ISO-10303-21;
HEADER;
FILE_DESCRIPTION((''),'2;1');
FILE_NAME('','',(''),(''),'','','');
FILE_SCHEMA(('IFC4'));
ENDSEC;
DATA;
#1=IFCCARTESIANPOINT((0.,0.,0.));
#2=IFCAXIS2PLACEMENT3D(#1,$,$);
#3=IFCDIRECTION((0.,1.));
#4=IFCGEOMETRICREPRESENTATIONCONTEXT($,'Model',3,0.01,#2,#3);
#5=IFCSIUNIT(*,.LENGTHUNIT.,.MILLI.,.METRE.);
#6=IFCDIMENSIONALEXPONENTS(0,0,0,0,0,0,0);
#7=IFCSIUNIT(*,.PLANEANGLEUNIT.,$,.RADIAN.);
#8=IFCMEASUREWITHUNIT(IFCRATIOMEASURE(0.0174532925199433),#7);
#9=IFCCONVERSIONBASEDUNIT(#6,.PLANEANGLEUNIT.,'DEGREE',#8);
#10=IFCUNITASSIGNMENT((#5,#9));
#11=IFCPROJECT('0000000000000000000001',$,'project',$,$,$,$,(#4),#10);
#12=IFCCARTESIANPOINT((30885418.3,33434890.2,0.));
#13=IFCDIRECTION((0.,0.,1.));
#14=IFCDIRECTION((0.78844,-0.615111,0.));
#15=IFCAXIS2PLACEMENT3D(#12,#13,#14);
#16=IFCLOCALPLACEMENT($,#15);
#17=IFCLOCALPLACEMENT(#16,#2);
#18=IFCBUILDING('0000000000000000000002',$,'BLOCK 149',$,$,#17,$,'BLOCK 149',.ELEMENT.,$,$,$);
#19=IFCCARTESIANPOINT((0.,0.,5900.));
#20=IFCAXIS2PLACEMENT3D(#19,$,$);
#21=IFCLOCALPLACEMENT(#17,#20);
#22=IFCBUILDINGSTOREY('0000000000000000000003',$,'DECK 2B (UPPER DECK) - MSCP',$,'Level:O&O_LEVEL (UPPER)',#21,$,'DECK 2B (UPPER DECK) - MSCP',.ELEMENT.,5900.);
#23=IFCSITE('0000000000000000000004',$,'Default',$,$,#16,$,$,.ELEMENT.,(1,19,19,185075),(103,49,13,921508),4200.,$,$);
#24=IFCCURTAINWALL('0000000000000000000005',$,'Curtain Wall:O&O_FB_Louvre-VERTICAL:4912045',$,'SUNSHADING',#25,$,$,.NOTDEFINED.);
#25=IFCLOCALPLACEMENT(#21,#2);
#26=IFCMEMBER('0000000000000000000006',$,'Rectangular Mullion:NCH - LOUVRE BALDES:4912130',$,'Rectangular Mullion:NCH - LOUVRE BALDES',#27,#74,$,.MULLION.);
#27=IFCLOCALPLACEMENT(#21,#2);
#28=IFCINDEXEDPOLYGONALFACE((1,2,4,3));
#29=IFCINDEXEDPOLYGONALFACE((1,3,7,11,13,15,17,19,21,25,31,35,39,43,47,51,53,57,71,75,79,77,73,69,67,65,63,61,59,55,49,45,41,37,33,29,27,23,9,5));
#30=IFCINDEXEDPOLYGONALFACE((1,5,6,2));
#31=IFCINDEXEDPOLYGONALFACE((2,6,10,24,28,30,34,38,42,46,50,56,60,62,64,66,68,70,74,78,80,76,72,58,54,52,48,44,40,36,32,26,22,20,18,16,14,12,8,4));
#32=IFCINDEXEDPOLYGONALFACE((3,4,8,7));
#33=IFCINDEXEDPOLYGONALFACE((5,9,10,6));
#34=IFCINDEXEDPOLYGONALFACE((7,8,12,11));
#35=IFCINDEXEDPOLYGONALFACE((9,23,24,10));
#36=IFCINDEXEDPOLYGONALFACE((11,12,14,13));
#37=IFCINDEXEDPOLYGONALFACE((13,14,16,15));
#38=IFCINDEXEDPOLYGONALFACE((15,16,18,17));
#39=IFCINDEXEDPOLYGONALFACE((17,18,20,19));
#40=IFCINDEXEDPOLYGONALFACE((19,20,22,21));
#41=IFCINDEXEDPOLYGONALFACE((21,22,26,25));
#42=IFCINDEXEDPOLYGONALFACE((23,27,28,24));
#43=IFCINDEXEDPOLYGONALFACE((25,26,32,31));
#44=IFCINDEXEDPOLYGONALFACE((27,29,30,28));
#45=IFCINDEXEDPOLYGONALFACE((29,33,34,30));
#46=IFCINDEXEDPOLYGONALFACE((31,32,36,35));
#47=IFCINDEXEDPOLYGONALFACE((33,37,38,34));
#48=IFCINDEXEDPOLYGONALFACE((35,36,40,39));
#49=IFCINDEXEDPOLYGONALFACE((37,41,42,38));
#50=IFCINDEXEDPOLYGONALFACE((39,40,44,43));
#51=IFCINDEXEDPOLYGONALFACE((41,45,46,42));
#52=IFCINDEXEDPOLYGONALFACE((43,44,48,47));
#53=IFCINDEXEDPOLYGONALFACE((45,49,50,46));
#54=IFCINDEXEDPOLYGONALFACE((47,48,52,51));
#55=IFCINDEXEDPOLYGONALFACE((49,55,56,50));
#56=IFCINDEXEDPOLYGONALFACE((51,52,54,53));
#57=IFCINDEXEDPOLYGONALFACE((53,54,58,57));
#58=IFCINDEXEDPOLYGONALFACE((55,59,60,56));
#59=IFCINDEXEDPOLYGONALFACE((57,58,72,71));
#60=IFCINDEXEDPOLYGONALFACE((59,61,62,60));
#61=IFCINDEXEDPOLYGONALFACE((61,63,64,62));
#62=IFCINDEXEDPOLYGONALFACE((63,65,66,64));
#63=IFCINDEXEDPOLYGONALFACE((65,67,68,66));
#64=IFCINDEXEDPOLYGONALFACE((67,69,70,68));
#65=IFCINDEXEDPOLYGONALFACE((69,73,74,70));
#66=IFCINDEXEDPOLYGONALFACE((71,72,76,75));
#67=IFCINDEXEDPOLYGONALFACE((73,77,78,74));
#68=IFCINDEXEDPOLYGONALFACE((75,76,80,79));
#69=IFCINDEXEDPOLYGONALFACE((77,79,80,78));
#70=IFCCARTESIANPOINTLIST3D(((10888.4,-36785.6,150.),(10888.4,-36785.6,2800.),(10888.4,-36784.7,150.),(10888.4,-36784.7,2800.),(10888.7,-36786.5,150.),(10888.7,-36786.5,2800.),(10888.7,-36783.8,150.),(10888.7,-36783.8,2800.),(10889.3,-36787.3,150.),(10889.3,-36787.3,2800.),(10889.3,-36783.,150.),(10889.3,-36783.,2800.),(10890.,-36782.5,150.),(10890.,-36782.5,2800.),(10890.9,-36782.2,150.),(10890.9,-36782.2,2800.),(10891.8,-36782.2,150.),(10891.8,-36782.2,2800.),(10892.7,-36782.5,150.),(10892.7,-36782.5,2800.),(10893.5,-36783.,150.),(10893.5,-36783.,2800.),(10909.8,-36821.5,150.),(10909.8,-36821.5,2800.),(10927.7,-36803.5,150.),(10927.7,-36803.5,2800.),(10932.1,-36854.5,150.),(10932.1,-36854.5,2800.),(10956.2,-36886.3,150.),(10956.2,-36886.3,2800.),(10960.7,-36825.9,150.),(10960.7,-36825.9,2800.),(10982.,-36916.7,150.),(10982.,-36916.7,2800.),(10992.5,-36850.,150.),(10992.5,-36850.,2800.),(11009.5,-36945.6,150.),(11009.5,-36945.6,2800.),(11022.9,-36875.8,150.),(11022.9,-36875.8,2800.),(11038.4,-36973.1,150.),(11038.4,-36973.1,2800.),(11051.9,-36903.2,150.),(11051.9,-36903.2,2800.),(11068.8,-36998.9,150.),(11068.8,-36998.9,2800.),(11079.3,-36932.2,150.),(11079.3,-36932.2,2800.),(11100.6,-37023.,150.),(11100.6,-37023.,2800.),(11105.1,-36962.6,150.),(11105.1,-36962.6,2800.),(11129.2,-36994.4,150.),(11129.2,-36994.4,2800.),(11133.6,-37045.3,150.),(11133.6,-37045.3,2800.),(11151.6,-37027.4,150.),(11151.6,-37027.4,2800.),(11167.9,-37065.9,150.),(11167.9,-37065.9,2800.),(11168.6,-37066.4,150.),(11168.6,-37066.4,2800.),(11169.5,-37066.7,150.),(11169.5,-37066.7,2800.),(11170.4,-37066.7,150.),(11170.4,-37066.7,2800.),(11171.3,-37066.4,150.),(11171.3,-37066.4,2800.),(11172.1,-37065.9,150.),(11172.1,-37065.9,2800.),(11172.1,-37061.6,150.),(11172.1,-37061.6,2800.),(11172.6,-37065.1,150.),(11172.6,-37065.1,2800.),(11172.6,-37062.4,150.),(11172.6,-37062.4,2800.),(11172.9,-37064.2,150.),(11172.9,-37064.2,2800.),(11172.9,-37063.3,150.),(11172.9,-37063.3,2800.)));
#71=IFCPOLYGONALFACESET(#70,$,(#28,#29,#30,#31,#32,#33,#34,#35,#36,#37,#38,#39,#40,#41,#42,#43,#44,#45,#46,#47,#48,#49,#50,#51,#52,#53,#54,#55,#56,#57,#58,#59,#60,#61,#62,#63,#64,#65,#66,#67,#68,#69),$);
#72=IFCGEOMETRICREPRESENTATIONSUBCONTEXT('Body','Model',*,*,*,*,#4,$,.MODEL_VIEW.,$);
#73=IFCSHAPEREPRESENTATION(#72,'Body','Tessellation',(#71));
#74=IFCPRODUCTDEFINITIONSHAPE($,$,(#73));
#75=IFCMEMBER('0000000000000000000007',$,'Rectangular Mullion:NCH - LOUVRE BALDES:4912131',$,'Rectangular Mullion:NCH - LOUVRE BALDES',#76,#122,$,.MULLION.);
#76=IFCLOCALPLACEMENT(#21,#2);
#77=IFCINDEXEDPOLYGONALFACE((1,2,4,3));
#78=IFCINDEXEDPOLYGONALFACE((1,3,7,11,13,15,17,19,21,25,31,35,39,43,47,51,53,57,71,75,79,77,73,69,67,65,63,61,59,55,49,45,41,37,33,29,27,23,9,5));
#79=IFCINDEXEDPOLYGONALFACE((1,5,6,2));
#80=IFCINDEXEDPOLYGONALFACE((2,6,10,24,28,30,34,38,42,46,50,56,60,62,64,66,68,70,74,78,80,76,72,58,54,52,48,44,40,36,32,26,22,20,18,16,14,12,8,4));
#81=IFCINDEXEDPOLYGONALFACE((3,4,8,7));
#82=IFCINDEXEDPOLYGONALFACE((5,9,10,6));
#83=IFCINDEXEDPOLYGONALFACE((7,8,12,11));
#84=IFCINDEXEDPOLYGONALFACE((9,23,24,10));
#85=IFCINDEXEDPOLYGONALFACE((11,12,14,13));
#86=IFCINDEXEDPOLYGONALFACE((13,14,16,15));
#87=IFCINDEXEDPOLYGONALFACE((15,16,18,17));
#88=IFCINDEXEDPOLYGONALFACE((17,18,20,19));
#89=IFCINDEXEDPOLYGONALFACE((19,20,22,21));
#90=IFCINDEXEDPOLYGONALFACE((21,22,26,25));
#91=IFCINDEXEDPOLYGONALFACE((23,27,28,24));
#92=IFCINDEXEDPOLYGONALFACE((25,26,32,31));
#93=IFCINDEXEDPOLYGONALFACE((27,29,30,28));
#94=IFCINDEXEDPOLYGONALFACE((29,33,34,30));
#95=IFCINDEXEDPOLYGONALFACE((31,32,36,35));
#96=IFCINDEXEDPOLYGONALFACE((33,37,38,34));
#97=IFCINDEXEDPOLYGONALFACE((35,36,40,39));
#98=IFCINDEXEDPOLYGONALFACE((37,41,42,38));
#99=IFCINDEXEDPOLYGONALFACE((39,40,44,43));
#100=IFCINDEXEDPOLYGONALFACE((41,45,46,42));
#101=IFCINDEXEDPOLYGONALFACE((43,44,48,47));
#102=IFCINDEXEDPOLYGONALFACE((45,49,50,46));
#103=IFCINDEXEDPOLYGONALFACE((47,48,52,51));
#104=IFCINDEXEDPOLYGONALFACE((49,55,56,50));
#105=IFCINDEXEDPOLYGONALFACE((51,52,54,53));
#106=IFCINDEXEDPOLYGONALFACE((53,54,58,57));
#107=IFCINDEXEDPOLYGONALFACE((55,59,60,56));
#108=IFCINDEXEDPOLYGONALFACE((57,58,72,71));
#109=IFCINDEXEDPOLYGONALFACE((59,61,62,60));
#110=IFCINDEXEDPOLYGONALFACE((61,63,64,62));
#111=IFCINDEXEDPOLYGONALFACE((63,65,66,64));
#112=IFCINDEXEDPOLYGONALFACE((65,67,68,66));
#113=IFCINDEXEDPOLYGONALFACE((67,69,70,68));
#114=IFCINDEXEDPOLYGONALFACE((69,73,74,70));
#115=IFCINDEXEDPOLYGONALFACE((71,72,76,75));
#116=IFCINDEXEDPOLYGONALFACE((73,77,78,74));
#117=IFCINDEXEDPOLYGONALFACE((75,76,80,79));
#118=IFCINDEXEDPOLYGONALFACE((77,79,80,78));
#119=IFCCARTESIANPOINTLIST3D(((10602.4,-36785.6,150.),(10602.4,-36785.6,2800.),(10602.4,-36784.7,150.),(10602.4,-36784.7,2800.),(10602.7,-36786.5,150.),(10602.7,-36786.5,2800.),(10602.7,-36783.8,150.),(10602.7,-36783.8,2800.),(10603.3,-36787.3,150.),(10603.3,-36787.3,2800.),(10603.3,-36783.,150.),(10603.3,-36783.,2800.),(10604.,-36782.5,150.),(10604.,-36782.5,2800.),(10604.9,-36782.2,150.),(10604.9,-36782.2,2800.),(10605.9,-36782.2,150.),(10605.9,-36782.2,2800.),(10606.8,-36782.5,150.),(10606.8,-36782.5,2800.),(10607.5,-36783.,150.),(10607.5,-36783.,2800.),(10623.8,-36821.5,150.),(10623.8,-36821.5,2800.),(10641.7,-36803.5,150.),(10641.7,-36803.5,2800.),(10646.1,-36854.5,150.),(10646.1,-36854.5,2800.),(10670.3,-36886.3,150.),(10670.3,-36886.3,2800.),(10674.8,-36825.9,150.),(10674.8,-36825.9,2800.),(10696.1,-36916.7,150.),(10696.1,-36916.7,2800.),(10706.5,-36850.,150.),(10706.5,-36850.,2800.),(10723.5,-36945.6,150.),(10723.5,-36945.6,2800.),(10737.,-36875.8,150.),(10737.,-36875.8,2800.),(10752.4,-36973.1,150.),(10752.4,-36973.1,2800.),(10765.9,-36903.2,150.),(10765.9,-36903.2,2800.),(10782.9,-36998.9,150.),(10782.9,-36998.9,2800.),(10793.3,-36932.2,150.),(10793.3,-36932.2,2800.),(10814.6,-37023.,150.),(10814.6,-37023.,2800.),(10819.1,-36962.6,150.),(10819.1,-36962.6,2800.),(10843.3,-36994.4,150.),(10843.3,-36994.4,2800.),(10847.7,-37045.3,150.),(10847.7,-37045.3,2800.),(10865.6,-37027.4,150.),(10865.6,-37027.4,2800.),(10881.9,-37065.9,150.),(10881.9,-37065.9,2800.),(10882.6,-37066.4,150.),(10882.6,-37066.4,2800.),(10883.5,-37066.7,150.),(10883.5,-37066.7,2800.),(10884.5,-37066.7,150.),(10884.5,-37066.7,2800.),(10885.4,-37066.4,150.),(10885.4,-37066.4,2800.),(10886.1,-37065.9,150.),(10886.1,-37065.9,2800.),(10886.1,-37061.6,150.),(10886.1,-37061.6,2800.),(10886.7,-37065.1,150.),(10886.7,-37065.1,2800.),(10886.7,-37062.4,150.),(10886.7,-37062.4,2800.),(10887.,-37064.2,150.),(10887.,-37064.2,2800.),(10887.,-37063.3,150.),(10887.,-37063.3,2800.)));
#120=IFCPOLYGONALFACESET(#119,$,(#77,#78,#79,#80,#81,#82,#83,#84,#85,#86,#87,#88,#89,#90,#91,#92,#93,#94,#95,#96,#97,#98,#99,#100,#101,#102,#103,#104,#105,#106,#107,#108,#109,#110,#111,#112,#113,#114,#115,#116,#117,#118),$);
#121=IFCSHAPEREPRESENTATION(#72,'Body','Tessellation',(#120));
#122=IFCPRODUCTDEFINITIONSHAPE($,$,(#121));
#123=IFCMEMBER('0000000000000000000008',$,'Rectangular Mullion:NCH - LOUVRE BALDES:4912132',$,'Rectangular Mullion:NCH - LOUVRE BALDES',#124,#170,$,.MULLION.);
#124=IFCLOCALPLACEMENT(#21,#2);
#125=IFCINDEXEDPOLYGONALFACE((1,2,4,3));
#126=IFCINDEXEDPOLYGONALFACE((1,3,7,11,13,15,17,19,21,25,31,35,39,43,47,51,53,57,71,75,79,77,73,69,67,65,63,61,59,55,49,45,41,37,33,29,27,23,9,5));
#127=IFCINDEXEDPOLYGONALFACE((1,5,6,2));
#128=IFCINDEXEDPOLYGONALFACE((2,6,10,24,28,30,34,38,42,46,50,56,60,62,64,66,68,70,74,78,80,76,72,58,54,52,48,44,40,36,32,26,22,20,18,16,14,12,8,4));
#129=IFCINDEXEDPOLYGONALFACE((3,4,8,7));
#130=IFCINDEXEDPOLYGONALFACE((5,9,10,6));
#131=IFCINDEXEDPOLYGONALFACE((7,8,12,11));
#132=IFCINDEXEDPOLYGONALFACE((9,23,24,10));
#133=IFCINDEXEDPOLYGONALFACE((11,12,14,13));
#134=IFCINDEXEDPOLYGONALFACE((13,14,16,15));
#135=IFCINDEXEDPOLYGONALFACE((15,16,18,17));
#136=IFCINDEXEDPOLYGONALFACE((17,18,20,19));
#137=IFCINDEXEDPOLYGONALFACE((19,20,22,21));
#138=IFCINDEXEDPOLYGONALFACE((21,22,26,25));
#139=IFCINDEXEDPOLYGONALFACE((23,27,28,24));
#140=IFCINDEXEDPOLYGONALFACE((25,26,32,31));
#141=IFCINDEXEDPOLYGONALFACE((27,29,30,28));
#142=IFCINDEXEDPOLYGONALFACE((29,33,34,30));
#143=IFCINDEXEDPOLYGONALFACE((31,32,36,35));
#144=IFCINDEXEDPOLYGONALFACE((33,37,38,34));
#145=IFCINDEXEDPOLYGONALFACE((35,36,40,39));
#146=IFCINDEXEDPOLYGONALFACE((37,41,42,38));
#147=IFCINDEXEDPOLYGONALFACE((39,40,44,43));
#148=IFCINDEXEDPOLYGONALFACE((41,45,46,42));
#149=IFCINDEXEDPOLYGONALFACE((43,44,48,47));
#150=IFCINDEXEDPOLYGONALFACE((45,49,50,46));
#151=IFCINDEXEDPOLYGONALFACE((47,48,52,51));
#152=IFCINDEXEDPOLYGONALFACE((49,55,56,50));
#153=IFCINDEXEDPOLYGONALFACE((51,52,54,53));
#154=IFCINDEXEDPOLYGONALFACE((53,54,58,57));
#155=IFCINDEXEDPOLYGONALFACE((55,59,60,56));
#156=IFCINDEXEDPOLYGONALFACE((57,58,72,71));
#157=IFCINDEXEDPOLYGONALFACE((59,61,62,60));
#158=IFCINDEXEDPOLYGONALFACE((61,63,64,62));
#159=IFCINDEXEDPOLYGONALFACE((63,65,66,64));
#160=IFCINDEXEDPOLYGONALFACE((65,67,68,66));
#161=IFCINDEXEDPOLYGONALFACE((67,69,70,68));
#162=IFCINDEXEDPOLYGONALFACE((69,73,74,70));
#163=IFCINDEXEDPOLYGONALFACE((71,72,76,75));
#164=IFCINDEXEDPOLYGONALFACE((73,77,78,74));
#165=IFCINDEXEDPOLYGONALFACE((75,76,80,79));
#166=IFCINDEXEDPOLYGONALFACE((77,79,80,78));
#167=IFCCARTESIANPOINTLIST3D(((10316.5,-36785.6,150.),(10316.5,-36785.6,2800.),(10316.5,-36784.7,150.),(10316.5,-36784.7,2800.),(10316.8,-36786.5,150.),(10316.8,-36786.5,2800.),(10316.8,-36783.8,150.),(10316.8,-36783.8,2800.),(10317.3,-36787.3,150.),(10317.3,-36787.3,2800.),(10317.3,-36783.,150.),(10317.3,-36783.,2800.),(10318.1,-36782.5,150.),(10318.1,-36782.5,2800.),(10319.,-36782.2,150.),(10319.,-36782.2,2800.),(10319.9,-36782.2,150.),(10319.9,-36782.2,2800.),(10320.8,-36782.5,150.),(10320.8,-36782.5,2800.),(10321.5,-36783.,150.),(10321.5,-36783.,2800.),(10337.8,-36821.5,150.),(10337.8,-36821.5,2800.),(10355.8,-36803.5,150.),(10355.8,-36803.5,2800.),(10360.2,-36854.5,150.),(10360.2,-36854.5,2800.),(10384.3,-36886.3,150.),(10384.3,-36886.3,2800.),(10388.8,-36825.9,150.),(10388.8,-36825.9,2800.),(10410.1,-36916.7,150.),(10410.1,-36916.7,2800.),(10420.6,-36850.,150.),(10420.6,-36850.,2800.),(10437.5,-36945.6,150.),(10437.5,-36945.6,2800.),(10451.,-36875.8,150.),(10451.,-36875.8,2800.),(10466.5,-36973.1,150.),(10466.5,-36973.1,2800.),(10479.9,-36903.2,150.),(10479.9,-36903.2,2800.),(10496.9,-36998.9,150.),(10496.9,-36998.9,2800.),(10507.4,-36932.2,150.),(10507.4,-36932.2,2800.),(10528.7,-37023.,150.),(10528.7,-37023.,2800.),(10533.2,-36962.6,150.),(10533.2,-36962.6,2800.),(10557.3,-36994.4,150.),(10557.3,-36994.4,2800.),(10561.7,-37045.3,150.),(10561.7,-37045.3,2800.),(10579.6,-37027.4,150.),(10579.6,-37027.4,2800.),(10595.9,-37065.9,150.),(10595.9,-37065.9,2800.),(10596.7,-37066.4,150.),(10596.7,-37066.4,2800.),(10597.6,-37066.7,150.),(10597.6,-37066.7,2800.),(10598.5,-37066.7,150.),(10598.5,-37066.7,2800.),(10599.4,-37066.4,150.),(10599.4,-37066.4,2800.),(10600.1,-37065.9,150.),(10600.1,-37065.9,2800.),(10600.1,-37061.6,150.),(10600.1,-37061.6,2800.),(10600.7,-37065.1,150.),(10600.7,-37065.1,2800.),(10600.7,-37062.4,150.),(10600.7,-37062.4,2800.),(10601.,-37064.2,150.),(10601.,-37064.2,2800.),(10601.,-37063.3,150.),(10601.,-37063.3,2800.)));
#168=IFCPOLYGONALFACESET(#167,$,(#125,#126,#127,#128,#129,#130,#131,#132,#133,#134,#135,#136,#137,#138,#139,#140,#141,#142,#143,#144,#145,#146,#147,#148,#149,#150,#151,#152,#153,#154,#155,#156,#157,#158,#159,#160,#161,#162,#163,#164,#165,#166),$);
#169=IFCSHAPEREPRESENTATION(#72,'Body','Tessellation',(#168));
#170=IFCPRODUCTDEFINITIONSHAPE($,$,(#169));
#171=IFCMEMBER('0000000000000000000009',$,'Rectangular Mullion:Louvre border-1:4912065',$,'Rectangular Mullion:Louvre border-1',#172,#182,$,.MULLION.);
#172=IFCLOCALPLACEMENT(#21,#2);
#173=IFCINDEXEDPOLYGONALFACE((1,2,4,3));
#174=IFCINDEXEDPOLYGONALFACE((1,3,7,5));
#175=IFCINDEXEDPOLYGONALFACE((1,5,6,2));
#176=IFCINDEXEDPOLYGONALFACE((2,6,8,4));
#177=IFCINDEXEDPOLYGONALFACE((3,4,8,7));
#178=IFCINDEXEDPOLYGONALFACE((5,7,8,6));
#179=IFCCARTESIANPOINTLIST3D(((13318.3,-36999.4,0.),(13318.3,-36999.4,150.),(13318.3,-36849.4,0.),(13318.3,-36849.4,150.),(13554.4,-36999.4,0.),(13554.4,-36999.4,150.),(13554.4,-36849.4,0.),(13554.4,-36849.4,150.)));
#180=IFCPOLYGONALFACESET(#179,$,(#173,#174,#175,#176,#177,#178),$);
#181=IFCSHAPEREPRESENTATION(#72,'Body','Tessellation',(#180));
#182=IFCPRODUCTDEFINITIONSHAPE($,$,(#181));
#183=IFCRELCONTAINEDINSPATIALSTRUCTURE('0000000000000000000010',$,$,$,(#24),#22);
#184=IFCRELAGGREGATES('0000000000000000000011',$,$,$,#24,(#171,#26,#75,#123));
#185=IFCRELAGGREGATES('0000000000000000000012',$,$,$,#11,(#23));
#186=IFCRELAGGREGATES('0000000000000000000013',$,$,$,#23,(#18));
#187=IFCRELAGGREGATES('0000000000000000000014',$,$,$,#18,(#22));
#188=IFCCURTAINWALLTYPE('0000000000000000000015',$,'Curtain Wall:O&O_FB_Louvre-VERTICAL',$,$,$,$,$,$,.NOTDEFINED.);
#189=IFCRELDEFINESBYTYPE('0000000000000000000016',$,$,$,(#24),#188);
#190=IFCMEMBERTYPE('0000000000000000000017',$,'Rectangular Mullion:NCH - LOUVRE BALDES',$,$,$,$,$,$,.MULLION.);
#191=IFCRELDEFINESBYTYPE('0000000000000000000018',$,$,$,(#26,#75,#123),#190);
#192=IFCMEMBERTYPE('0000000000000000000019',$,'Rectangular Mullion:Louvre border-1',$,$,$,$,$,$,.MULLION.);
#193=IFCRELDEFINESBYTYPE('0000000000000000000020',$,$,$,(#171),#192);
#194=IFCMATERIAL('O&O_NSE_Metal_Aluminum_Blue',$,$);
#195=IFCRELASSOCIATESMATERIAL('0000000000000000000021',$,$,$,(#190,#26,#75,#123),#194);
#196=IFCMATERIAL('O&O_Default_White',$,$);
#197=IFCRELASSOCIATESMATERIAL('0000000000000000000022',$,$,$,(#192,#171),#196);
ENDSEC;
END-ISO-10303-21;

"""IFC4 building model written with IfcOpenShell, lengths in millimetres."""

from ifc_helpers import new_model, entity, si_unit, converted_unit, direction, frame, origin, place, context, subcontext, project, spatial, indexed_curve, outline, extrude, source, transform, mapped, material, type_object, type_shapes, element, aggregate, save


model = new_model("IFC4")

# Units and contexts
model_context = context("Model", 3, precision=0.01, world=origin(), true_north=direction((0.0, 1.0)))
body_context = subcontext(model_context, "Body", "Model", "MODEL_VIEW")
ifc_project = project(units=[si_unit("LENGTHUNIT", "METRE", prefix="MILLI"), converted_unit("PLANEANGLEUNIT", "DEGREE", entity("IfcRatioMeasure", 0.0174532925199433), si_unit("PLANEANGLEUNIT", "RADIAN"), dimensions=[0, 0, 0, 0, 0, 0, 0])], contexts=[model_context])

# Site, building, storey
site_placement = place(None, frame((30885418.3, 33434890.2, 0.0), z_axis=(0.0, 0.0, 1.0), x_axis=(0.78844, -0.615111, 0.0)))
site = spatial("IfcSite", under=ifc_project, at=site_placement, Name="Default", CompositionType="ELEMENT", RefLatitude=(1, 19, 19, 185075), RefLongitude=(103, 49, 13, 921508), RefElevation=4200.0)
building_placement = place(site_placement, origin())
building = spatial("IfcBuilding", under=site, at=building_placement, Name="BLOCK 149", LongName="BLOCK 149", CompositionType="ELEMENT")
storey_placement = place(building_placement, frame((0.0, 0.0, 5900.0)))
storey = spatial("IfcBuildingStorey", under=building, at=storey_placement, Name="DECK 2B (UPPER DECK) - MSCP", ObjectType="Level:O&O_LEVEL (UPPER)", LongName="DECK 2B (UPPER DECK) - MSCP", CompositionType="ELEMENT", Elevation=5900.0)

# Curtain wall, members
curtain_wall_type = type_object("IfcCurtainWallType", Name="Curtain Wall:O&O_FB_Louvre-VERTICAL", PredefinedType="NOTDEFINED")
curtain_wall_placement = place(storey_placement, frame((0.0, 0.0, -5900.0)))
curtain_wall = element("IfcCurtainWall", 1, at=curtain_wall_placement, inside=storey, type_object=curtain_wall_type, Name="Curtain Wall:O&O_FB_Louvre-VERTICAL:4912045", ObjectType="SUNSHADING", PredefinedType="NOTDEFINED")
ifc_material_1 = material(Name="O&O_Default_White")
placement = place(building_placement, origin())
ifc_material_2 = material(Name="O&O_NSE_Metal_Aluminum_Blue")
member_type_1 = type_object("IfcMemberType", Name="Rectangular Mullion:NCH - LOUVRE BALDES", PredefinedType="MULLION", material=ifc_material_2)
shared_shape_1 = source(origin(), body_context, "Body", "SweptSolid", [
    extrude(outline(indexed_curve([(55.9, -188.9), (54.8, -149.1), (51.6, -109.3), (46.1, -69.8), (38.6, -30.6), (28.9, 8.1), (17.1, 46.2), (3.3, 83.6), (-12.6, 120.2), (-30.4, 155.9), (-50.1, 190.5), (-50.5, 191.4), (-51.1, 192.1), (-52.0, 192.5), (-52.9, 192.7), (-53.8, 192.6), (-54.7, 192.2), (-55.4, 191.6), (-55.8, 190.8), (-56.0, 189.9), (-55.9, 188.9), (-54.8, 149.1), (-51.6, 109.3), (-46.1, 69.8), (-38.6, 30.6), (-28.9, -8.1), (-17.1, -46.2), (-3.3, -83.6), (12.6, -120.2), (30.4, -155.9), (50.1, -190.5), (50.5, -191.4), (51.1, -192.1), (52.0, -192.5), (52.9, -192.7), (53.8, -192.6), (54.7, -192.2), (55.4, -191.6), (55.8, -190.8), (56.0, -189.9), (55.9, -188.9)], self_intersect=False)), frame((0.0, 0.0, -2650.0), z_axis=(0.0, 0.0, 1.0), x_axis=(0.490779, -0.871284, 0.0)), (0.0, 0.0, 1.0), 2650.0),
])
type_shapes(member_type_1, [shared_shape_1])
member_1_placement = place(placement, frame((11030.7, -36924.4, 6050.0), z_axis=(0.0, 0.0, -1.0), x_axis=(-1.0, 0.0, 0.0)))
member_1 = element("IfcMember", 2, at=member_1_placement, type_object=member_type_1, material=ifc_material_2, Name="Rectangular Mullion:NCH - LOUVRE BALDES:4912130", ObjectType="Rectangular Mullion:NCH - LOUVRE BALDES", PredefinedType="MULLION", context=body_context, shape_type="MappedRepresentation", body=[
    mapped(shared_shape_1, transform((0.0, 0.0, 0.0), scale=1.0)),
])
member_2_placement = place(placement, frame((10744.7, -36924.4, 6050.0), z_axis=(0.0, 0.0, -1.0), x_axis=(-1.0, 0.0, 0.0)))
member_2 = element("IfcMember", 3, at=member_2_placement, type_object=member_type_1, material=ifc_material_2, Name="Rectangular Mullion:NCH - LOUVRE BALDES:4912131", ObjectType="Rectangular Mullion:NCH - LOUVRE BALDES", PredefinedType="MULLION", context=body_context, shape_type="MappedRepresentation", body=[
    mapped(shared_shape_1, transform((0.0, 0.0, 0.0), scale=1.0)),
])
member_3_placement = place(placement, frame((10458.7, -36924.4, 6050.0), z_axis=(0.0, 0.0, -1.0), x_axis=(-1.0, 0.0, 0.0)))
member_3 = element("IfcMember", 4, at=member_3_placement, type_object=member_type_1, material=ifc_material_2, Name="Rectangular Mullion:NCH - LOUVRE BALDES:4912132", ObjectType="Rectangular Mullion:NCH - LOUVRE BALDES", PredefinedType="MULLION", context=body_context, shape_type="MappedRepresentation", body=[
    mapped(shared_shape_1, transform((0.0, 0.0, 0.0), scale=1.0)),
])
member_type_2 = type_object("IfcMemberType", Name="Rectangular Mullion:Louvre border-1", PredefinedType="MULLION", material=ifc_material_1)
shared_shape_2 = source(origin(), body_context, "Body", "SweptSolid", [
    extrude(outline(indexed_curve([(-75.0, -75.0), (75.0, -75.0), (75.0, 75.0), (-75.0, 75.0), (-75.0, -75.0)], self_intersect=False)), frame((-75.0, 0.0, -236.1), z_axis=(0.0, 0.0, 1.0), x_axis=(0.0, -1.0, 0.0)), (0.0, 0.0, 1.0), 236.1),
])
type_shapes(member_type_2, [shared_shape_2])
member_4_placement = place(placement, frame((13554.4, -36924.4, 5900.0), z_axis=(1.0, 0.0, 0.0), x_axis=(0.0, 0.0, -1.0)))
member_4 = element("IfcMember", 5, at=member_4_placement, type_object=member_type_2, material=ifc_material_1, Name="Rectangular Mullion:Louvre border-1:4912065", ObjectType="Rectangular Mullion:Louvre border-1", PredefinedType="MULLION", context=body_context, shape_type="MappedRepresentation", body=[
    mapped(shared_shape_2, transform((0.0, 0.0, 0.0), scale=1.0)),
])
aggregate(curtain_wall, [member_4, member_1, member_2, member_3])

save(model, "model.ifc")
